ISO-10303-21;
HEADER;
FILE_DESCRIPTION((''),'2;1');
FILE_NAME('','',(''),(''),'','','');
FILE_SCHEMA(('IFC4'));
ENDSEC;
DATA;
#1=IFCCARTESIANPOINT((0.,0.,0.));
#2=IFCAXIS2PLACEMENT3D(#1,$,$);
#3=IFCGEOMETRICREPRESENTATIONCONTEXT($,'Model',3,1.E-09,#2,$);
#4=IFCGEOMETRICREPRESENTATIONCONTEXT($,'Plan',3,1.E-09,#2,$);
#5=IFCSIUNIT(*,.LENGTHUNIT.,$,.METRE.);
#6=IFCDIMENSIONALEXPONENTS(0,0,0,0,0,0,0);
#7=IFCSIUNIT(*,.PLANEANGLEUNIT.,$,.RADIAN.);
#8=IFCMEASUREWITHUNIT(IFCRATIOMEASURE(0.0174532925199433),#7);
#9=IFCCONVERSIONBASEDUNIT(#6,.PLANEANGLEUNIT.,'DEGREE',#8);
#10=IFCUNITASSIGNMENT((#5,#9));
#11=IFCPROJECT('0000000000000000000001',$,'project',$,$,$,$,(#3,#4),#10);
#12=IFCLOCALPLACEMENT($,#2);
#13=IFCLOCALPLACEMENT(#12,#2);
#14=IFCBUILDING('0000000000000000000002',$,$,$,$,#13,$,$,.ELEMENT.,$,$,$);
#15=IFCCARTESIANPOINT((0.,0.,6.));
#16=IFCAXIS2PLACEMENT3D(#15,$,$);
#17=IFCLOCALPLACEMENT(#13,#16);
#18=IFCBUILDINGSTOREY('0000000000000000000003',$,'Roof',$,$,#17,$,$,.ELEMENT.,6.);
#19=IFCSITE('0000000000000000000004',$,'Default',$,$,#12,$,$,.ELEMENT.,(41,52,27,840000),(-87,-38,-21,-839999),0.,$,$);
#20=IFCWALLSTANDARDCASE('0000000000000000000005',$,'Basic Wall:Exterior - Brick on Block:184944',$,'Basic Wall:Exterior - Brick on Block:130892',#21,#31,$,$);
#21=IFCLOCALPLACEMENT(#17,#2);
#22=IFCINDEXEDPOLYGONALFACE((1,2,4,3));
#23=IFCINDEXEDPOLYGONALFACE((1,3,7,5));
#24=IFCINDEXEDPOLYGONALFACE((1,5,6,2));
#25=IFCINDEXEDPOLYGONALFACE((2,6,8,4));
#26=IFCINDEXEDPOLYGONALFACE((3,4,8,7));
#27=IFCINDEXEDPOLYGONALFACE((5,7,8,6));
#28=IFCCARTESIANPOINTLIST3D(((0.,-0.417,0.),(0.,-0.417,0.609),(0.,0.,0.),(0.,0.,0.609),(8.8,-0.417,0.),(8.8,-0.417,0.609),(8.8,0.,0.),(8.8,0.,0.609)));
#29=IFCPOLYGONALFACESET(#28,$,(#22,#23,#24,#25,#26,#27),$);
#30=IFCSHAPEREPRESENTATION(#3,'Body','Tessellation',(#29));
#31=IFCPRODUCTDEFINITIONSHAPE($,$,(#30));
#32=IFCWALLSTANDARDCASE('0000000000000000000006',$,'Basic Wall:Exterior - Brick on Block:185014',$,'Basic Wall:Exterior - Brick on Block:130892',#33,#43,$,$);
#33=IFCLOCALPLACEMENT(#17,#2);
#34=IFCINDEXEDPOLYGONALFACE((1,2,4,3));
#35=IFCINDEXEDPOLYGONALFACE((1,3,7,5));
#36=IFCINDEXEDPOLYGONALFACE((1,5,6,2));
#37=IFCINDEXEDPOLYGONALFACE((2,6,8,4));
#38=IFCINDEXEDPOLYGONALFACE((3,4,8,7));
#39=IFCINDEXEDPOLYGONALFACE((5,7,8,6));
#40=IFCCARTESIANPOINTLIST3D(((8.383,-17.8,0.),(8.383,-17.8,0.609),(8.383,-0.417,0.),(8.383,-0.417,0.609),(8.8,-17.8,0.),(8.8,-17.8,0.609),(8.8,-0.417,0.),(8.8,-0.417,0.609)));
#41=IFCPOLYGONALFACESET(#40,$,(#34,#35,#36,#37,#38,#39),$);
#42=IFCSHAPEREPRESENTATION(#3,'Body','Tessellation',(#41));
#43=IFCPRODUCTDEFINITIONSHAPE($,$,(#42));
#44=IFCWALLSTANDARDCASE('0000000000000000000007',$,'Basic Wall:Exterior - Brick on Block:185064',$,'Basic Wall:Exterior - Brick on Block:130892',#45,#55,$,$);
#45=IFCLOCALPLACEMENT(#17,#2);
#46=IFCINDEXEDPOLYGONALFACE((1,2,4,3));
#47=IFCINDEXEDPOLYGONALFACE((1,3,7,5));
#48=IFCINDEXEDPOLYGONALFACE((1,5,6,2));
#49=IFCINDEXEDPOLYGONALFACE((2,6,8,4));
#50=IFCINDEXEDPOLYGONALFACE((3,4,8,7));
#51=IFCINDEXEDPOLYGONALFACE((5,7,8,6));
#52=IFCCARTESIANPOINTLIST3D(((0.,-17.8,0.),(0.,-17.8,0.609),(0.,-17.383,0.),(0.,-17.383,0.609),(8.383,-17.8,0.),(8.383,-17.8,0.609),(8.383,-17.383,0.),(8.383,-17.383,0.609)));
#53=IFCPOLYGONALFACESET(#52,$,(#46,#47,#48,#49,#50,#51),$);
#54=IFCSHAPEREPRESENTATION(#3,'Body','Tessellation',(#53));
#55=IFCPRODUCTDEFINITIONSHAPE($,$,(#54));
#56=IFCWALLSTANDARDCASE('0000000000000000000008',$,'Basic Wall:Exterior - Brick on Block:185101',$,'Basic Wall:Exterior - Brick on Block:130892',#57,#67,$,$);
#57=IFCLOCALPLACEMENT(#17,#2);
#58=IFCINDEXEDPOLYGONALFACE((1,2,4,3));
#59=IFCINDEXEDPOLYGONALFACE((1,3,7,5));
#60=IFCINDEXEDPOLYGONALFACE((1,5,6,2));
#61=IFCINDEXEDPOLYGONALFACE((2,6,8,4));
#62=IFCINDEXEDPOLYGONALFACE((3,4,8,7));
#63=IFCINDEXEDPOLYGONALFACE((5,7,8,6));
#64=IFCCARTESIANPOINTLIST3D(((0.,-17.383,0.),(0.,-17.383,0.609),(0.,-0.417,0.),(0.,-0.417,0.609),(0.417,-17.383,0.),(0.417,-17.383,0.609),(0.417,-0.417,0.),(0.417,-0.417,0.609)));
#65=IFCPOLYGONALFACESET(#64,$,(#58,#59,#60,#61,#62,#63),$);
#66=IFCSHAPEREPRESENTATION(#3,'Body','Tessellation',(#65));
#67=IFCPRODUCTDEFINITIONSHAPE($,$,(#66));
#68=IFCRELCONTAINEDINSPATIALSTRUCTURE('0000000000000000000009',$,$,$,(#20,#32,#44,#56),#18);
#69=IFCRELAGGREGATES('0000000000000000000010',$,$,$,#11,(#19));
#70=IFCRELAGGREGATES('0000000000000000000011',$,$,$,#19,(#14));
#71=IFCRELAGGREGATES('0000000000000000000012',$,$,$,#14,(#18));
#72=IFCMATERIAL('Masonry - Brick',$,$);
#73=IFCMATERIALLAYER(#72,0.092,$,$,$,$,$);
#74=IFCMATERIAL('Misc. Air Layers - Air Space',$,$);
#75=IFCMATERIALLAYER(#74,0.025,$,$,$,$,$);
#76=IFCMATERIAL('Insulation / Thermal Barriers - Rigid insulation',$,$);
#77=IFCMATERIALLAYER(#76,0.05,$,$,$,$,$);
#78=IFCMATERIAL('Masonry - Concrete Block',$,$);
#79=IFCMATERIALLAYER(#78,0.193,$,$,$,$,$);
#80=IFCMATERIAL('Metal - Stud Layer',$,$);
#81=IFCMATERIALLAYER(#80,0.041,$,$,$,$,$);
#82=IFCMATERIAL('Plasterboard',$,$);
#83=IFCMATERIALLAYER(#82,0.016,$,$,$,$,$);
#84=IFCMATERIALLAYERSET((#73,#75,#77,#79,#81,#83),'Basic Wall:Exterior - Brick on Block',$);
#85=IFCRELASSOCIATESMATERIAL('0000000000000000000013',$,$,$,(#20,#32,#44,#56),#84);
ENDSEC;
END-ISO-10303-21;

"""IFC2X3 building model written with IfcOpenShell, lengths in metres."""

from ifc_helpers import new_model, entity, si_unit, converted_unit, frame, frame_2d, origin, place, context, project, spatial, rectangle, extrude, material, layer, layer_set, layer_usage, element, save


model = new_model("IFC2X3")

# Units and contexts
model_context = context("Model", 3, precision=1e-09, world=origin())
plan_context = context("Plan", 3, precision=1e-09, world=origin())
ifc_project = project(units=[si_unit("LENGTHUNIT", "METRE"), converted_unit("PLANEANGLEUNIT", "DEGREE", entity("IfcRatioMeasure", 0.0174532925199433), si_unit("PLANEANGLEUNIT", "RADIAN"), dimensions=[0, 0, 0, 0, 0, 0, 0])], contexts=[model_context, plan_context])

# Site, building, storey
site_placement = place(None, origin())
site = spatial("IfcSite", under=ifc_project, at=site_placement, Name="Default", CompositionType="ELEMENT", RefLatitude=(41, 52, 27, 840000), RefLongitude=(-87, -38, -21, -839999), RefElevation=0.0)
building_placement = place(site_placement, origin())
building = spatial("IfcBuilding", under=site, at=building_placement, CompositionType="ELEMENT")
storey_placement = place(building_placement, frame((0.0, 0.0, 6.0)))
storey = spatial("IfcBuildingStorey", under=building, at=storey_placement, Name="Roof", CompositionType="ELEMENT", Elevation=6.0)

# Walls
ifc_material_1 = material(Name="Masonry - Brick")
ifc_layer_1 = layer(ifc_material_1, 0.092)
ifc_material_2 = material(Name="Misc. Air Layers - Air Space")
ifc_layer_2 = layer(ifc_material_2, 0.025)
ifc_material_3 = material(Name="Insulation / Thermal Barriers - Rigid insulation")
ifc_layer_3 = layer(ifc_material_3, 0.05)
ifc_material_4 = material(Name="Masonry - Concrete Block")
ifc_layer_4 = layer(ifc_material_4, 0.193)
ifc_material_5 = material(Name="Metal - Stud Layer")
ifc_layer_5 = layer(ifc_material_5, 0.041)
ifc_material_6 = material(Name="Plasterboard")
ifc_layer_6 = layer(ifc_material_6, 0.016)
ifc_layer_set = layer_set([ifc_layer_1, ifc_layer_2, ifc_layer_3, ifc_layer_4, ifc_layer_5, ifc_layer_6], Name="Basic Wall:Exterior - Brick on Block")
ifc_layer_usage_1 = layer_usage(ifc_layer_set, "AXIS2", "NEGATIVE", 0.2085)
wall_1_placement = place(storey_placement, frame((0.0, -0.2085, 0.0)))
element("IfcWallStandardCase", 1, at=wall_1_placement, inside=storey, material=ifc_layer_usage_1, Name="Basic Wall:Exterior - Brick on Block:184944", ObjectType="Basic Wall:Exterior - Brick on Block:130892", context=model_context, shape_type="SweptSolid", body=[
    extrude(rectangle(XDim=8.8, YDim=0.417, at=frame_2d((4.4, 0.0), x_axis=(-1.0, 0.0))), origin(), (0.0, 0.0, 1.0), 0.609),
])
ifc_layer_usage_2 = layer_usage(ifc_layer_set, "AXIS2", "NEGATIVE", 0.2085)
wall_2_placement = place(storey_placement, frame((8.5915, -0.417, 0.0), z_axis=(0.0, 0.0, 1.0), x_axis=(0.0, -1.0, 0.0)))
element("IfcWallStandardCase", 2, at=wall_2_placement, inside=storey, material=ifc_layer_usage_2, Name="Basic Wall:Exterior - Brick on Block:185014", ObjectType="Basic Wall:Exterior - Brick on Block:130892", context=model_context, shape_type="SweptSolid", body=[
    extrude(rectangle(XDim=17.383, YDim=0.417, at=frame_2d((8.6915, 0.0), x_axis=(-1.0, 0.0))), origin(), (0.0, 0.0, 1.0), 0.609),
])
ifc_layer_usage_3 = layer_usage(ifc_layer_set, "AXIS2", "NEGATIVE", 0.2085)
wall_3_placement = place(storey_placement, frame((8.383, -17.5915, 0.0), z_axis=(0.0, 0.0, 1.0), x_axis=(-1.0, 0.0, 0.0)))
element("IfcWallStandardCase", 3, at=wall_3_placement, inside=storey, material=ifc_layer_usage_3, Name="Basic Wall:Exterior - Brick on Block:185064", ObjectType="Basic Wall:Exterior - Brick on Block:130892", context=model_context, shape_type="SweptSolid", body=[
    extrude(rectangle(XDim=8.383, YDim=0.417, at=frame_2d((4.1915, 0.0), x_axis=(-1.0, 0.0))), origin(), (0.0, 0.0, 1.0), 0.609),
])
ifc_layer_usage_4 = layer_usage(ifc_layer_set, "AXIS2", "NEGATIVE", 0.2085)
wall_4_placement = place(storey_placement, frame((0.2085, -17.383, 0.0), z_axis=(0.0, 0.0, 1.0), x_axis=(0.0, 1.0, 0.0)))
element("IfcWallStandardCase", 4, at=wall_4_placement, inside=storey, material=ifc_layer_usage_4, Name="Basic Wall:Exterior - Brick on Block:185101", ObjectType="Basic Wall:Exterior - Brick on Block:130892", context=model_context, shape_type="SweptSolid", body=[
    extrude(rectangle(XDim=16.966, YDim=0.417, at=frame_2d((8.483, 0.0), x_axis=(-1.0, 0.0))), origin(), (0.0, 0.0, 1.0), 0.609),
])

save(model, "model.ifc")
